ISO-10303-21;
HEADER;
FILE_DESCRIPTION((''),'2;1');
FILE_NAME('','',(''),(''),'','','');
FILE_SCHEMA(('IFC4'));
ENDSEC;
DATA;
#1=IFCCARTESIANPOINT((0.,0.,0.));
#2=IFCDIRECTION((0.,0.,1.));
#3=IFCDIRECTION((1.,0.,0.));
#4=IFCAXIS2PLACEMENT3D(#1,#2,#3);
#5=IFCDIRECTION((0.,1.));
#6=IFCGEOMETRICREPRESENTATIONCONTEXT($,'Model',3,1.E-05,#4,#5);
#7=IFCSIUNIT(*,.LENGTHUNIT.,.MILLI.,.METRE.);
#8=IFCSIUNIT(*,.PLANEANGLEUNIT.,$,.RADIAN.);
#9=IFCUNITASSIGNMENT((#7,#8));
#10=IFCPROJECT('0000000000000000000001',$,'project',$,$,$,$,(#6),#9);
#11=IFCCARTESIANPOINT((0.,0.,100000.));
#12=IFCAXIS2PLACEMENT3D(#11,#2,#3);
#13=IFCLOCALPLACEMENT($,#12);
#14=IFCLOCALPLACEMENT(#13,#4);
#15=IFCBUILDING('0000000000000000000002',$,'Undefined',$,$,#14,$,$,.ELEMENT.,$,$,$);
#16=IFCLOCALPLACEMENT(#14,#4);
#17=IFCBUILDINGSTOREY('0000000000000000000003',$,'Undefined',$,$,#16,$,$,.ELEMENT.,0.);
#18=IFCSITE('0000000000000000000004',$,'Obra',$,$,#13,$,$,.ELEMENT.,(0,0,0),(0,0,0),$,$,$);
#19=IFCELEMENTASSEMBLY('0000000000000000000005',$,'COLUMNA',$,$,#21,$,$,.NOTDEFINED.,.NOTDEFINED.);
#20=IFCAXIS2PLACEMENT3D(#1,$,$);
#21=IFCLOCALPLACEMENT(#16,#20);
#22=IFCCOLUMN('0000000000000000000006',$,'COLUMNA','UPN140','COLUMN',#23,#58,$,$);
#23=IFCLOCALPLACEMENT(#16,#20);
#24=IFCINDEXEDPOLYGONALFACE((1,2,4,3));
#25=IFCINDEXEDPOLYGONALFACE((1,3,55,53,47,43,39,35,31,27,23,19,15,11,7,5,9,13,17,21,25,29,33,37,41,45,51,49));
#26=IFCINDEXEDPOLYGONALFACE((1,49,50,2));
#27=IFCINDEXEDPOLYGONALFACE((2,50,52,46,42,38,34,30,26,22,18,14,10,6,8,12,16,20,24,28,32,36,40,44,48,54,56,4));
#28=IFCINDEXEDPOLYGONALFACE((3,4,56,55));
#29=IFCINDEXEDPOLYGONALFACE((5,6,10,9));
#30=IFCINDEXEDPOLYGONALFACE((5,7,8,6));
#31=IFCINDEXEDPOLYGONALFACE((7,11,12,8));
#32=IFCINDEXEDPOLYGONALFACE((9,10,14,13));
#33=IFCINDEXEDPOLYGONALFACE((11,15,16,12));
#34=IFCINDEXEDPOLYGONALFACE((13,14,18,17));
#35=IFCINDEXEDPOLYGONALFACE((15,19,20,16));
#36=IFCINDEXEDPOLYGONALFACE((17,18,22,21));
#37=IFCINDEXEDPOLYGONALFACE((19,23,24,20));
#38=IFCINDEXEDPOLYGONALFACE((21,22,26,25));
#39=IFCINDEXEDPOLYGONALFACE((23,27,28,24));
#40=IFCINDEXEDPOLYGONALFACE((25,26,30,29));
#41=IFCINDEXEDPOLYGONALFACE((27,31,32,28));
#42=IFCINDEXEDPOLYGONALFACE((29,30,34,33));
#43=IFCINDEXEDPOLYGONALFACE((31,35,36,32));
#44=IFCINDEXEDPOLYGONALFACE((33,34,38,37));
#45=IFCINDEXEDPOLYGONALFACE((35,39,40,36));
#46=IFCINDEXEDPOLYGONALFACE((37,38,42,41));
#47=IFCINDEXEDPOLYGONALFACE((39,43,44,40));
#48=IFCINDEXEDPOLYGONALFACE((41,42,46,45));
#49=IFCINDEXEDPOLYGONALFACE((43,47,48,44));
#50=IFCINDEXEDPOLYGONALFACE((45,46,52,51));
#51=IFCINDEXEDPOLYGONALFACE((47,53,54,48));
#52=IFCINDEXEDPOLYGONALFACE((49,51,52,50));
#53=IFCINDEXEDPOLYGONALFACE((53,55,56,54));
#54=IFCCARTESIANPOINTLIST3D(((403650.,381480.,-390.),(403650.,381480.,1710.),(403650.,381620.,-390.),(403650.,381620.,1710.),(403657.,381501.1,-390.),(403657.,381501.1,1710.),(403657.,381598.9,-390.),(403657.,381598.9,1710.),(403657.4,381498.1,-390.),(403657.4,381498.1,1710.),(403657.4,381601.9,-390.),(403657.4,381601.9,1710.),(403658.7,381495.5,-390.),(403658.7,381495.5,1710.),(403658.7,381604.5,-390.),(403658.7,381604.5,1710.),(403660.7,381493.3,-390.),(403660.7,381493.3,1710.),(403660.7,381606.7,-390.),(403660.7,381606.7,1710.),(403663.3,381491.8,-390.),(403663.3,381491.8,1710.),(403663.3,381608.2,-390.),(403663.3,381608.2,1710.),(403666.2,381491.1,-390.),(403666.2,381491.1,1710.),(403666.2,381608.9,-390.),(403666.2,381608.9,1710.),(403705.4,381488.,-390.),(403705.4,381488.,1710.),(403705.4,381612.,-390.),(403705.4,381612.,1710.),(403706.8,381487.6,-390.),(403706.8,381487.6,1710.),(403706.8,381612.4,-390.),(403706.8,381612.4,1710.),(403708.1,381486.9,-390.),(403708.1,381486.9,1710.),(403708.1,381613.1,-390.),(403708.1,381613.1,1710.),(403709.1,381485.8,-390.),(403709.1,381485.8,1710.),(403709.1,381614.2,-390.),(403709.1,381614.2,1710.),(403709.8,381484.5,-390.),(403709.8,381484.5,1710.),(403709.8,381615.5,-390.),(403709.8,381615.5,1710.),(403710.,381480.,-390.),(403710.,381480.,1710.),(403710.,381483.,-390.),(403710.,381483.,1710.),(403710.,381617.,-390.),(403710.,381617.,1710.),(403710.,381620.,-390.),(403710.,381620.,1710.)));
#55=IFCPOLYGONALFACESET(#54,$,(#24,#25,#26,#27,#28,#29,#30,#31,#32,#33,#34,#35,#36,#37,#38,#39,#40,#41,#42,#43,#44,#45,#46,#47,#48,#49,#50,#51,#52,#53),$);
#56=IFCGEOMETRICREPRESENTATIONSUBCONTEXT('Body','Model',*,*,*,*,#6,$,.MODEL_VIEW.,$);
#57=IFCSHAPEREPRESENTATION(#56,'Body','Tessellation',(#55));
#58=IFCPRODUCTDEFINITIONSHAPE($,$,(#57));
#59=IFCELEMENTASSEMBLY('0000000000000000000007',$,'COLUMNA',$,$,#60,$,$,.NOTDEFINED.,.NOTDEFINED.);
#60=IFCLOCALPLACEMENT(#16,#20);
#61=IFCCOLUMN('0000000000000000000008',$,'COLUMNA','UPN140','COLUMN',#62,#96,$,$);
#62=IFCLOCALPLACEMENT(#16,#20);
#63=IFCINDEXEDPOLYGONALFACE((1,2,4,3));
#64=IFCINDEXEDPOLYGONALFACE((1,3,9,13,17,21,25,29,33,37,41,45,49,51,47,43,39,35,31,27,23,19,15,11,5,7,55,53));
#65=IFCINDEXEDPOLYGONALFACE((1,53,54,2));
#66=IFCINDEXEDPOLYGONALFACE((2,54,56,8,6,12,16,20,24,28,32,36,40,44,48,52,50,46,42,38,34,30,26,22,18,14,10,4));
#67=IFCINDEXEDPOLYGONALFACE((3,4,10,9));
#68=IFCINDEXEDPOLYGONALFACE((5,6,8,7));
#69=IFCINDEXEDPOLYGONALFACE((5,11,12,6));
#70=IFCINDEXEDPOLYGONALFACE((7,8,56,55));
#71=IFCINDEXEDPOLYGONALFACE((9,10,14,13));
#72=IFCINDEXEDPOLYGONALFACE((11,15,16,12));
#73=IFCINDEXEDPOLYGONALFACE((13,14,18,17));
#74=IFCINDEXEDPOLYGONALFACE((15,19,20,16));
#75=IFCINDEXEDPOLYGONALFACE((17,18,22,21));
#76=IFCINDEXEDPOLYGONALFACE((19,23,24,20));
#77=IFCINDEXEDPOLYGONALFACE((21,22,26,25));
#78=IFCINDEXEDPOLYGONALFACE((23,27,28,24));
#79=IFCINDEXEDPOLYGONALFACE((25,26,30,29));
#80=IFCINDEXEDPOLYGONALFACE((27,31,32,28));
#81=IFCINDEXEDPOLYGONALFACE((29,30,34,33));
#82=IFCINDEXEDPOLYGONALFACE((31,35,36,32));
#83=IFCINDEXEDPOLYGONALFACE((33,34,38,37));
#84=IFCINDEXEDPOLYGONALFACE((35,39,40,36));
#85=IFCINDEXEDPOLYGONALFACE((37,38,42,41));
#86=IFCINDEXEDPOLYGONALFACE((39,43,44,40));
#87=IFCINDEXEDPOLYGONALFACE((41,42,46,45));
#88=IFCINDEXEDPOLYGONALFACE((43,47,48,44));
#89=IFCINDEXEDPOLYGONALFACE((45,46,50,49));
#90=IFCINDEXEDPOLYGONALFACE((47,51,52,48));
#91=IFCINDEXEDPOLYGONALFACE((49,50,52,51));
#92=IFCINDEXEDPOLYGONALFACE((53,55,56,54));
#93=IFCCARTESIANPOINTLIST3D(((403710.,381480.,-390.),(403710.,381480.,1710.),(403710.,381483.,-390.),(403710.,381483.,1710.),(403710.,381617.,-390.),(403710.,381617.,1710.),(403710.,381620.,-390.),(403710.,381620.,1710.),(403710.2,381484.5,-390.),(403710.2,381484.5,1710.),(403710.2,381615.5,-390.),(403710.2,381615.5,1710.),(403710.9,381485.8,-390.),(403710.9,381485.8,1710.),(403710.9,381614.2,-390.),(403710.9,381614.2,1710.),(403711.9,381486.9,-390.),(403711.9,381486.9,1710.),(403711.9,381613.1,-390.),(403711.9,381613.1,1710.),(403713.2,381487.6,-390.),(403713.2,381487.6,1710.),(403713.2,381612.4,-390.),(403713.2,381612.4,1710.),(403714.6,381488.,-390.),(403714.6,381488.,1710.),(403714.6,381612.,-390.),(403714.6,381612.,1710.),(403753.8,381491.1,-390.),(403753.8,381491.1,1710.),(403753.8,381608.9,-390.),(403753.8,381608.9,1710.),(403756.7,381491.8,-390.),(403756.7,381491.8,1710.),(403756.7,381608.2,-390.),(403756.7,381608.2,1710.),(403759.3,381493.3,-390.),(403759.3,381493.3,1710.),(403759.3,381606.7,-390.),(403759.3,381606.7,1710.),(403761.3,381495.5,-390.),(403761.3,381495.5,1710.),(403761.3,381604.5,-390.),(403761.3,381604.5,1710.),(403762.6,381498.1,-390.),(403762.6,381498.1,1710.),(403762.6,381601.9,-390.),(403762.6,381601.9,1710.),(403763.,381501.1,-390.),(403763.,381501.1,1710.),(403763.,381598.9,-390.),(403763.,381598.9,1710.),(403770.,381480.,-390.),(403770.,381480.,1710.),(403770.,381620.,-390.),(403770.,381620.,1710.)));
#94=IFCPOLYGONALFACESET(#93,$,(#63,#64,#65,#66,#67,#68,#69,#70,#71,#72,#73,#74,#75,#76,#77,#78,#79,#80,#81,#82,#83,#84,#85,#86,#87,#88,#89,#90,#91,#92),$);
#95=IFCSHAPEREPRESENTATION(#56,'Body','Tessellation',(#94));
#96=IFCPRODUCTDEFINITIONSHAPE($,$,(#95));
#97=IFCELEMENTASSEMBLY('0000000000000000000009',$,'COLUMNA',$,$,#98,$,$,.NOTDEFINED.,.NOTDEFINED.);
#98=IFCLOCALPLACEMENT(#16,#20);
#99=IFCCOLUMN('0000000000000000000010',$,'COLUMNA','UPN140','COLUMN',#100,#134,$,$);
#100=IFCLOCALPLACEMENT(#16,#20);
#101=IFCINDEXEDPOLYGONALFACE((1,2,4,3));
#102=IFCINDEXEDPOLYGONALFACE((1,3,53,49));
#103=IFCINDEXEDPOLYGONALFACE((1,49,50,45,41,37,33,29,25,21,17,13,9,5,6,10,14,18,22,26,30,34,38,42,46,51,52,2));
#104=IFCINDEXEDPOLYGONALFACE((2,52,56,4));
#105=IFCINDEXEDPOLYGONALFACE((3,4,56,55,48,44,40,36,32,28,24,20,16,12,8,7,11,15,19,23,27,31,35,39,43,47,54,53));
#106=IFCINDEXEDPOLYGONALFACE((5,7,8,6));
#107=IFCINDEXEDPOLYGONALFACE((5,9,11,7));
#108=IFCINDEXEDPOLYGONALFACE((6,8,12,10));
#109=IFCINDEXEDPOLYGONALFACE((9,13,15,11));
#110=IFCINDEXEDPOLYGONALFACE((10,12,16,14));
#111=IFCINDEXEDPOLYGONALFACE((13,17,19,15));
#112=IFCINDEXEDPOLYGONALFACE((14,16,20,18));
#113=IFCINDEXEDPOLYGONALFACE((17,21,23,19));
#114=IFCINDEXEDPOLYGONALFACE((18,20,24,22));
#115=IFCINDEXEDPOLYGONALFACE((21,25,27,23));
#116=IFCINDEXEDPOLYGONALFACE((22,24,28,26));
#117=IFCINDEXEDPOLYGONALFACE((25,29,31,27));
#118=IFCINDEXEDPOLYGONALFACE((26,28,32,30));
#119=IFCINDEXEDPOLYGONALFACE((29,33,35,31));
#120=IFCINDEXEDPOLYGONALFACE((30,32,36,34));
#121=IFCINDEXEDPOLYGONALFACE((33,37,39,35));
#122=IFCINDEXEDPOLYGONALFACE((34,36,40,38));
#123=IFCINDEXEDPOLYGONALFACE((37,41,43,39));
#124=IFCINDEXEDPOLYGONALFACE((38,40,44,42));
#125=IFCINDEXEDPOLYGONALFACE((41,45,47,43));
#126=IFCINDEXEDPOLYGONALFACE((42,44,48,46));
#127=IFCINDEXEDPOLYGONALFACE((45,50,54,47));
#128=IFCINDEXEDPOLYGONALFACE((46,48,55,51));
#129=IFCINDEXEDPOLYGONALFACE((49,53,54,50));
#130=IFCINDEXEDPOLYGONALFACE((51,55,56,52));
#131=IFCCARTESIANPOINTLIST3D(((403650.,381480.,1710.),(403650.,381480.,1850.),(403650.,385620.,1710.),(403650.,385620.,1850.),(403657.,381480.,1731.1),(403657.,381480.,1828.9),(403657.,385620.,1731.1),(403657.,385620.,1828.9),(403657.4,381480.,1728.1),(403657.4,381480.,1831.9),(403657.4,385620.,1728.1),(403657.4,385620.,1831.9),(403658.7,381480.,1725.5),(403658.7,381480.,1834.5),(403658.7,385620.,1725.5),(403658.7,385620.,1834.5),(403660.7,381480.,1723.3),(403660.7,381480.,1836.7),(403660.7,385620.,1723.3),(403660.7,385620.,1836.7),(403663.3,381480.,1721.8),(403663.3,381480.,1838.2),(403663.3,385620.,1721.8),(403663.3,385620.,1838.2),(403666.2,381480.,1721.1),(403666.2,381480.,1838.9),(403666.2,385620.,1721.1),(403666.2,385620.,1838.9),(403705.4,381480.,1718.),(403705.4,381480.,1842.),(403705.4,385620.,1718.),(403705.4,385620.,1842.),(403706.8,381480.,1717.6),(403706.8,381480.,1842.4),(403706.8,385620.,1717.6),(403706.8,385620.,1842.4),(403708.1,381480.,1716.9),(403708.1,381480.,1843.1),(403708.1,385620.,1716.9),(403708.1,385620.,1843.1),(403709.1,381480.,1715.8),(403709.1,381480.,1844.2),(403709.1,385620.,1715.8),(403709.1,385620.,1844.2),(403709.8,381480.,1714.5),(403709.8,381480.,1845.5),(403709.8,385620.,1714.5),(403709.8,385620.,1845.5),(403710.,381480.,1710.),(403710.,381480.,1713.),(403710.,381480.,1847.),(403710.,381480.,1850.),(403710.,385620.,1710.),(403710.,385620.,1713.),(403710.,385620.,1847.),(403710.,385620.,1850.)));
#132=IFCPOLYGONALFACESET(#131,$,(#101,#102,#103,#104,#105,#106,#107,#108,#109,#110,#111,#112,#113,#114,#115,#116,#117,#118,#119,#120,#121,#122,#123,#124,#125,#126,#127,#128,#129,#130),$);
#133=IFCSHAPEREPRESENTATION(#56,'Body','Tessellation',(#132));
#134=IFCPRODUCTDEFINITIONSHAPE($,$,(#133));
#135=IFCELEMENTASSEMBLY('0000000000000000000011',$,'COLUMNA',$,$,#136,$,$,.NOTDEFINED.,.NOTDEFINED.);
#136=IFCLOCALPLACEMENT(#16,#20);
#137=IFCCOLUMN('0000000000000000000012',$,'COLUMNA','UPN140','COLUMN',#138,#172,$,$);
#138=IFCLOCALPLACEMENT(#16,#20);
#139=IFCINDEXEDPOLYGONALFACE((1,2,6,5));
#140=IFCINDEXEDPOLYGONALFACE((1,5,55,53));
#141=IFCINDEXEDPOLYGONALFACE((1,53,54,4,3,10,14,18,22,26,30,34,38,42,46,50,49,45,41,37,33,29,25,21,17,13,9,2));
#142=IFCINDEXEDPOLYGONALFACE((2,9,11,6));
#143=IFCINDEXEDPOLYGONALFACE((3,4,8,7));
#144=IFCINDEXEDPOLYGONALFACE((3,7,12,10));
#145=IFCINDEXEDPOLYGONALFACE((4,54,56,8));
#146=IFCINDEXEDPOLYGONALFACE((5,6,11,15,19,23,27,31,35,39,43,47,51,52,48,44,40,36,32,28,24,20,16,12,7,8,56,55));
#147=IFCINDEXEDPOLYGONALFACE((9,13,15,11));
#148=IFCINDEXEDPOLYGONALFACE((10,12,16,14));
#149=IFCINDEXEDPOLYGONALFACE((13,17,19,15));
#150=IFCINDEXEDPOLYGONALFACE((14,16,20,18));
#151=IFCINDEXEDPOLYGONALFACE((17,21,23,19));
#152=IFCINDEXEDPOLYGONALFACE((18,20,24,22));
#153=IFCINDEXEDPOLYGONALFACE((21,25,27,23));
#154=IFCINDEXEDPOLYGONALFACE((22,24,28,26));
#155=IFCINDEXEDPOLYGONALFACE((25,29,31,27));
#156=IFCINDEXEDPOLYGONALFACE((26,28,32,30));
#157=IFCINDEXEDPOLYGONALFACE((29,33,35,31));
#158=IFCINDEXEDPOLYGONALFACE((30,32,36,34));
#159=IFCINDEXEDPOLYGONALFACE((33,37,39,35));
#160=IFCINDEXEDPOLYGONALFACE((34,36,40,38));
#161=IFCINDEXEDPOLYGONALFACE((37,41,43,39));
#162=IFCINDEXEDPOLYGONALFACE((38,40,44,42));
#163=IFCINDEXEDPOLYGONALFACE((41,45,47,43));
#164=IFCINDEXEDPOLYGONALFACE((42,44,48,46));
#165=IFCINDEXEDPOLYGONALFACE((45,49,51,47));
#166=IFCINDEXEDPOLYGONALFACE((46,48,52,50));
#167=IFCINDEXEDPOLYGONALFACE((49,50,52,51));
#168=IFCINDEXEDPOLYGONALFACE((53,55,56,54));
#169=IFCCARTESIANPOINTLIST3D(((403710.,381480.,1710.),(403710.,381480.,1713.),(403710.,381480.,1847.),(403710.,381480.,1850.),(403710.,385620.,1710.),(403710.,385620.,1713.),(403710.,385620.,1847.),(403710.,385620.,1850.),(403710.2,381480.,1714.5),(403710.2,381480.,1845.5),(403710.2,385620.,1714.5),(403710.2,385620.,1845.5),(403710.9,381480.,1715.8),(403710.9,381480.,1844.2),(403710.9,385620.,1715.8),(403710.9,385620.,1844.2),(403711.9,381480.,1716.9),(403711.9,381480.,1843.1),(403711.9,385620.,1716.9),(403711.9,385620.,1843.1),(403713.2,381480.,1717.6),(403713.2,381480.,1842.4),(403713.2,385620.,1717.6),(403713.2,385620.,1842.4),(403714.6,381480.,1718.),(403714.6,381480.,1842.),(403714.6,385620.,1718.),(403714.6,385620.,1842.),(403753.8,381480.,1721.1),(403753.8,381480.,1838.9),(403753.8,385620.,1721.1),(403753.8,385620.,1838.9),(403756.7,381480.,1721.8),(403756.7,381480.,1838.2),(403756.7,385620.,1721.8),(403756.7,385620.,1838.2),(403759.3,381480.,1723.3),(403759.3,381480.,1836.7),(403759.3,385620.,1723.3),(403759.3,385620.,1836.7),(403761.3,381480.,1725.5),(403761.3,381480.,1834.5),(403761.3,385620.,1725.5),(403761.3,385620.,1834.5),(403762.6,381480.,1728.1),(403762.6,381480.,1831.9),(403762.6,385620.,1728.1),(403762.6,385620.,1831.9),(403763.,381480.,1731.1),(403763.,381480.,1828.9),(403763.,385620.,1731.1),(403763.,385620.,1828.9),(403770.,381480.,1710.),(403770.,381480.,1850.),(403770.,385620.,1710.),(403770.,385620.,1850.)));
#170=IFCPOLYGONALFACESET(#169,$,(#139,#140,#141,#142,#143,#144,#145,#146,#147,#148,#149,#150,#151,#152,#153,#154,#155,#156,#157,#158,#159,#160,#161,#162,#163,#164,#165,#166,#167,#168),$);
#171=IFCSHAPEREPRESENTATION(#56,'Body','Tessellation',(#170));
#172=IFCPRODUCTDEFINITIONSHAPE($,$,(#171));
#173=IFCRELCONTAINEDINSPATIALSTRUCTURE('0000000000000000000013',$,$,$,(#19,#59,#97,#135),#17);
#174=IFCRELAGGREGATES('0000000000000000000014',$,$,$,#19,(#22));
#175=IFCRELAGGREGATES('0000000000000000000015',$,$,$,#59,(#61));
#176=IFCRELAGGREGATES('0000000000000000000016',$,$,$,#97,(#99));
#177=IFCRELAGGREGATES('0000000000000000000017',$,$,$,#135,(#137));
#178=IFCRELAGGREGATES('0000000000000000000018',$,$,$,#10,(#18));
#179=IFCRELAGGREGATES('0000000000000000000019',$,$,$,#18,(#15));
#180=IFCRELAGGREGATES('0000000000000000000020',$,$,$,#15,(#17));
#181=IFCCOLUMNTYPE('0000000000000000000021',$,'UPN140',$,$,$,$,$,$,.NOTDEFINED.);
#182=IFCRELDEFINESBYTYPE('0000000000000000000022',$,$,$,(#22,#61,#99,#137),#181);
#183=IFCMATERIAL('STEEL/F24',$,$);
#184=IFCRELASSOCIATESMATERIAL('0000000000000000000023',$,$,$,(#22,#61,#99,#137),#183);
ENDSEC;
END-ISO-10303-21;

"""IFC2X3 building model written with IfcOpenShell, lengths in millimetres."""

from ifc_helpers import new_model, si_unit, direction, frame, origin_with_axes, origin_2d_with_axis, place, context, subcontext, project, spatial, u_section, extrude, material, type_object, element, aggregate, save


model = new_model("IFC2X3")

# Units and contexts
model_context = context("Model", 3, precision=1e-05, world=origin_with_axes(), true_north=direction((0.0, 1.0)))
body_context = subcontext(model_context, "Body", "Model", "MODEL_VIEW")
ifc_project = project(units=[si_unit("LENGTHUNIT", "METRE", prefix="MILLI"), si_unit("PLANEANGLEUNIT", "RADIAN")], contexts=[model_context])

# Site, building, storey
site_placement = place(None, frame((0.0, 0.0, 100000.0), z_axis=(0.0, 0.0, 1.0), x_axis=(1.0, 0.0, 0.0)))
site = spatial("IfcSite", under=ifc_project, at=site_placement, Name="Obra", CompositionType="ELEMENT", RefLatitude=(0, 0, 0), RefLongitude=(0, 0, 0))
building_placement = place(site_placement, origin_with_axes())
building = spatial("IfcBuilding", under=site, at=building_placement, Name="Undefined", CompositionType="ELEMENT")
storey_placement = place(building_placement, origin_with_axes())
storey = spatial("IfcBuildingStorey", under=building, at=storey_placement, Name="Undefined", CompositionType="ELEMENT", Elevation=0.0)

# Element assemblies, columns
assembly_1_placement = place(storey_placement, origin_with_axes())
assembly_1 = element("IfcElementAssembly", 1, at=assembly_1_placement, inside=storey, Name="COLUMNA", AssemblyPlace="NOTDEFINED", PredefinedType="NOTDEFINED")
ifc_material_1 = material(Name="STEEL/F24")
column_type_1 = type_object("IfcColumnType", Name="UPN140", PredefinedType="NOTDEFINED")
column_1_placement = place(assembly_1_placement, frame((403680.0, 381550.0, 1710.0), z_axis=(0.0, 0.0, -1.0), x_axis=(0.0, 1.0, 0.0)))
column_1 = element("IfcColumn", 2, at=column_1_placement, type_object=column_type_1, material=ifc_material_1, Name="COLUMNA", Description="UPN140", ObjectType="COLUMN", context=body_context, shape_type="SweptSolid", body=[
    extrude(u_section(Depth=140.0, FlangeWidth=60.0, WebThickness=7.0, FlangeThickness=10.0, FilletRadius=10.0, EdgeRadius=5.0, FlangeSlope=0.07983, at=origin_2d_with_axis()), frame((0.0, 0.0, 2100.0), z_axis=(0.0, 0.0, -1.0), x_axis=(0.0, 1.0, 0.0)), (0.0, 0.0, 1.0), 2100.0),
])
aggregate(assembly_1, [column_1])
assembly_2_placement = place(storey_placement, origin_with_axes())
assembly_2 = element("IfcElementAssembly", 3, at=assembly_2_placement, inside=storey, Name="COLUMNA", AssemblyPlace="NOTDEFINED", PredefinedType="NOTDEFINED")
column_2_placement = place(assembly_2_placement, frame((403740.0, 381550.0, 1710.0), z_axis=(0.0, 0.0, -1.0), x_axis=(0.0, -1.0, 0.0)))
column_2 = element("IfcColumn", 4, at=column_2_placement, type_object=column_type_1, material=ifc_material_1, Name="COLUMNA", Description="UPN140", ObjectType="COLUMN", context=body_context, shape_type="SweptSolid", body=[
    extrude(u_section(Depth=140.0, FlangeWidth=60.0, WebThickness=7.0, FlangeThickness=10.0, FilletRadius=10.0, EdgeRadius=5.0, FlangeSlope=0.07983, at=origin_2d_with_axis()), frame((0.0, 0.0, 2100.0), z_axis=(0.0, 0.0, -1.0), x_axis=(0.0, 1.0, 0.0)), (0.0, 0.0, 1.0), 2100.0),
])
aggregate(assembly_2, [column_2])
assembly_3_placement = place(storey_placement, origin_with_axes())
assembly_3 = element("IfcElementAssembly", 5, at=assembly_3_placement, inside=storey, Name="COLUMNA", AssemblyPlace="NOTDEFINED", PredefinedType="NOTDEFINED")
column_3_placement = place(assembly_3_placement, frame((403680.0, 385620.0, 1780.0), z_axis=(0.0, -1.0, 0.0), x_axis=(0.0, 0.0, -1.0)))
column_3 = element("IfcColumn", 6, at=column_3_placement, type_object=column_type_1, material=ifc_material_1, Name="COLUMNA", Description="UPN140", ObjectType="COLUMN", context=body_context, shape_type="SweptSolid", body=[
    extrude(u_section(Depth=140.0, FlangeWidth=60.0, WebThickness=7.0, FlangeThickness=10.0, FilletRadius=10.0, EdgeRadius=5.0, FlangeSlope=0.07983, at=origin_2d_with_axis()), frame((0.0, 0.0, 4140.0), z_axis=(0.0, 0.0, -1.0), x_axis=(0.0, 1.0, 0.0)), (0.0, 0.0, 1.0), 4140.0),
])
aggregate(assembly_3, [column_3])
assembly_4_placement = place(storey_placement, origin_with_axes())
assembly_4 = element("IfcElementAssembly", 7, at=assembly_4_placement, inside=storey, Name="COLUMNA", AssemblyPlace="NOTDEFINED", PredefinedType="NOTDEFINED")
column_4_placement = place(assembly_4_placement, frame((403740.0, 385620.0, 1780.0), z_axis=(0.0, -1.0, 0.0), x_axis=(0.0, 0.0, 1.0)))
column_4 = element("IfcColumn", 8, at=column_4_placement, type_object=column_type_1, material=ifc_material_1, Name="COLUMNA", Description="UPN140", ObjectType="COLUMN", context=body_context, shape_type="SweptSolid", body=[
    extrude(u_section(Depth=140.0, FlangeWidth=60.0, WebThickness=7.0, FlangeThickness=10.0, FilletRadius=10.0, EdgeRadius=5.0, FlangeSlope=0.07983, at=origin_2d_with_axis()), frame((0.0, 0.0, 4140.0), z_axis=(0.0, 0.0, -1.0), x_axis=(0.0, 1.0, 0.0)), (0.0, 0.0, 1.0), 4140.0),
])
aggregate(assembly_4, [column_4])

save(model, "model.ifc")
